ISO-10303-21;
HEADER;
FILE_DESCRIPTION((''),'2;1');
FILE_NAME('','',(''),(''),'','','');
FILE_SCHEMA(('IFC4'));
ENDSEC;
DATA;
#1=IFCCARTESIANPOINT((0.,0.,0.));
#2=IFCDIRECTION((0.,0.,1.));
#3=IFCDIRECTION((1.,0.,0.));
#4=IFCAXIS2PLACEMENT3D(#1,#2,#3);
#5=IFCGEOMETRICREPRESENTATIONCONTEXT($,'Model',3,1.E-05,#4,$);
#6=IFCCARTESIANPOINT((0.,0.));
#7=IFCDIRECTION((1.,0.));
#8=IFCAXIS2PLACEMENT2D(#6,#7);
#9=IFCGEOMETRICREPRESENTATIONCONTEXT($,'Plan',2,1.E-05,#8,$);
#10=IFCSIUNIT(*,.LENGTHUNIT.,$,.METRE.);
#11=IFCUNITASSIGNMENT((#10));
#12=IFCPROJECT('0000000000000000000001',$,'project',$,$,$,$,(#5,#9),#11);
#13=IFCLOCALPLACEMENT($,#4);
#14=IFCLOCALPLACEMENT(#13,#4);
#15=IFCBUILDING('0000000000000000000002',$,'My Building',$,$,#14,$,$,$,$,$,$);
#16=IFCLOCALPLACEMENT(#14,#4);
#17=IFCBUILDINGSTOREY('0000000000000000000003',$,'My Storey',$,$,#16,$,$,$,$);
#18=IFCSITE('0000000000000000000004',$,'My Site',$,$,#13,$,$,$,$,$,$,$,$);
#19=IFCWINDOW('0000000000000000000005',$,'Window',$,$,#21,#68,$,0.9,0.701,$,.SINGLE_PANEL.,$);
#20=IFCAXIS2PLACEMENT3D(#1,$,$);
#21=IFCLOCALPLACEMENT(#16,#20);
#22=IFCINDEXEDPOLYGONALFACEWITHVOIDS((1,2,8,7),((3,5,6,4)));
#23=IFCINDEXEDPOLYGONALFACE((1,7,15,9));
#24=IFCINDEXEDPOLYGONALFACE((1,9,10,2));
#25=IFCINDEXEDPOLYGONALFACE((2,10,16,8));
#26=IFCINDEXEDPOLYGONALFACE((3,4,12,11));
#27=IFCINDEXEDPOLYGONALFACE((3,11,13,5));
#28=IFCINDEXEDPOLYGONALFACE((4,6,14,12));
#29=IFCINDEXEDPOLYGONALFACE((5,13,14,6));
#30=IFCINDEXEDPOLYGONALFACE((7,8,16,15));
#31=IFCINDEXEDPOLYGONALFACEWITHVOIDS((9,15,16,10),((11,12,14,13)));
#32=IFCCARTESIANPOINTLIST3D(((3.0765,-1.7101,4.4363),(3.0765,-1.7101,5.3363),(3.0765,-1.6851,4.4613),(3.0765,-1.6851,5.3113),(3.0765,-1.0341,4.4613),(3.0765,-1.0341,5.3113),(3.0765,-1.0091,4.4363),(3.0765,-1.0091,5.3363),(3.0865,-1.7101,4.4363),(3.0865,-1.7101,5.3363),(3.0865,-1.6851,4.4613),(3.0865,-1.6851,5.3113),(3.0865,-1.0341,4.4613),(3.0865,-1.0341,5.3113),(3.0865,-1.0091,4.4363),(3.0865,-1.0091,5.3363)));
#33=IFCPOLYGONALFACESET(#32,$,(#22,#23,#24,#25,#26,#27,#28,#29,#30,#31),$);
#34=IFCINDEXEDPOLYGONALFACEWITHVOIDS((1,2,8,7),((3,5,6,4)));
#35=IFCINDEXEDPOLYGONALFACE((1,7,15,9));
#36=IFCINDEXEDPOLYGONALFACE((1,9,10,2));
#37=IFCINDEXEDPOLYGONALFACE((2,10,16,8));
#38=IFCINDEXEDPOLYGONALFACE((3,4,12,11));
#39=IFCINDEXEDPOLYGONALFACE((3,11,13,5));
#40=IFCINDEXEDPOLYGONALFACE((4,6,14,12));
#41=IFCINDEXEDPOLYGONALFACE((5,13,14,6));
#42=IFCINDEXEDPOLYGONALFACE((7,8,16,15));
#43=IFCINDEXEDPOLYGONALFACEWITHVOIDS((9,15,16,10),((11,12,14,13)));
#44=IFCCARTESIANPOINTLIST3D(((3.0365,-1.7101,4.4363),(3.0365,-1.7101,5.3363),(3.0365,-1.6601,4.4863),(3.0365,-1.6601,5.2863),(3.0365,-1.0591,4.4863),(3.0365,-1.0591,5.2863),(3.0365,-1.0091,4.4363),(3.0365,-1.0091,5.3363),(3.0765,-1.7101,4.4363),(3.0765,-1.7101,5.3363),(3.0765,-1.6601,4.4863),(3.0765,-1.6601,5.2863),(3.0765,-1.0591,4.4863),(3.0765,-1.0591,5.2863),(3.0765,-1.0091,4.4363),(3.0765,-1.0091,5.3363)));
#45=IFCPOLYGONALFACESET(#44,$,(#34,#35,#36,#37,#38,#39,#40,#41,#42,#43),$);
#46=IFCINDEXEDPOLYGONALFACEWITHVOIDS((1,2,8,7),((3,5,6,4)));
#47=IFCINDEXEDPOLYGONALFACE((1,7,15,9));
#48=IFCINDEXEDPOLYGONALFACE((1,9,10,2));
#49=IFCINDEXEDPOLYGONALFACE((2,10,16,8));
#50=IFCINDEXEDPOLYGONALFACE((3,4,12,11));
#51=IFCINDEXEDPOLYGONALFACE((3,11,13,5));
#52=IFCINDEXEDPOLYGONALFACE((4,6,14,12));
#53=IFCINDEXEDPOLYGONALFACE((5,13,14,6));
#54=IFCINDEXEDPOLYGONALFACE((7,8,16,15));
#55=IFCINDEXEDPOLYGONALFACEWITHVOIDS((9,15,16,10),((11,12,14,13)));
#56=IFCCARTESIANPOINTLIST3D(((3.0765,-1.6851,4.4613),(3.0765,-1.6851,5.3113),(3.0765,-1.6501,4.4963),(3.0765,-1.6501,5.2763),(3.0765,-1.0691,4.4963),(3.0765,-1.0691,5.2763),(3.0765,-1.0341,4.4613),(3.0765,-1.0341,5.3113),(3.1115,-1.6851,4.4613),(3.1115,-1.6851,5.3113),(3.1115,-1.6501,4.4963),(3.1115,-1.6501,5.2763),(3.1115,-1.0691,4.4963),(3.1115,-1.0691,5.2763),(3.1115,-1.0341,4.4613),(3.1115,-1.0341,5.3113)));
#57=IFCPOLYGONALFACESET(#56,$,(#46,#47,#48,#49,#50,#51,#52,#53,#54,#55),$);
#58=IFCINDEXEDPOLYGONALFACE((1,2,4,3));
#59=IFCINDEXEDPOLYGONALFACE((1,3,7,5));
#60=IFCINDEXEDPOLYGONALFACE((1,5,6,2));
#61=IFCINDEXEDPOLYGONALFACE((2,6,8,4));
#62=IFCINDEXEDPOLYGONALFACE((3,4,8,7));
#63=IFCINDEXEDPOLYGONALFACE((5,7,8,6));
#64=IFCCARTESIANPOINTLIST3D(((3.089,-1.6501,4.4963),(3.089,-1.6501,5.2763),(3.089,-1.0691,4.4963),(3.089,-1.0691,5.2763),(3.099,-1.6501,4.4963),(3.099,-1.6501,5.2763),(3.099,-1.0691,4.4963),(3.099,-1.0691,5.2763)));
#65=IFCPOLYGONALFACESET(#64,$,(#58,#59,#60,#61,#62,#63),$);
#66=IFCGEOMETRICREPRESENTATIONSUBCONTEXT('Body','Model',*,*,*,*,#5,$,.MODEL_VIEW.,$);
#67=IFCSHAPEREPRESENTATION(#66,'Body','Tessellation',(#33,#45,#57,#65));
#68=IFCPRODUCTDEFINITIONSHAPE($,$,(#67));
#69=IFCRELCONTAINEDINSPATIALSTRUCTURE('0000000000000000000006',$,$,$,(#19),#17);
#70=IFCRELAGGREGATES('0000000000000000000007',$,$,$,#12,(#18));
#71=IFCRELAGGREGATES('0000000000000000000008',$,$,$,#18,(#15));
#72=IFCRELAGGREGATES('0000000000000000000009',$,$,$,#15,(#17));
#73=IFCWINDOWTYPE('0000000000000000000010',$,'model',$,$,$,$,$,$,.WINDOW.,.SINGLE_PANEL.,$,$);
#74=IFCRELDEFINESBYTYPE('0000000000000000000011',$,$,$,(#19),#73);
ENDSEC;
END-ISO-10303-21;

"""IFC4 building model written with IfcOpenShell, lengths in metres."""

from ifc_helpers import new_model, entity, si_unit, frame, origin_with_axes, origin_2d_with_axis, place, context, subcontext, project, spatial, line, indexed_curve, outline, extrude, shape, source, transform, mapped, type_object, type_shapes, element, save


model = new_model("IFC4")

# Units and contexts
model_context = context("Model", 3, precision=1e-05, world=origin_with_axes())
plan_context = context("Plan", 2, precision=1e-05, world=origin_2d_with_axis())
body_context_1 = subcontext(model_context, "Body", "Model", "MODEL_VIEW")
body_context_2 = subcontext(plan_context, "Body", "Plan", "PLAN_VIEW")
ifc_project = project(units=[si_unit("LENGTHUNIT", "METRE")], contexts=[model_context, plan_context])

# Site, building, storey
site_placement = place(None, origin_with_axes())
site = spatial("IfcSite", under=ifc_project, at=site_placement, Name="My Site")
building_placement = place(site_placement, origin_with_axes())
building = spatial("IfcBuilding", under=site, at=building_placement, Name="My Building")
storey_placement = place(building_placement, origin_with_axes())
storey = spatial("IfcBuildingStorey", under=building, at=storey_placement, Name="My Storey")

# Window
window_type_1 = type_object("IfcWindowType", Name="model", PartitioningType="SINGLE_PANEL", PredefinedType="WINDOW")
shared_shape_1 = source(origin_with_axes(), body_context_1, "Body", "SweptSolid", [
    extrude(outline(indexed_curve([(0.0, 0.0), (0.701, 0.0), (0.701, 0.9), (0.0, 0.9)], segments=[line(1, 2, 3, 4, 1)]), holes=[indexed_curve([(0.025, 0.025), (0.676, 0.025), (0.676, 0.875), (0.025, 0.875)], segments=[line(1, 2, 3, 4, 1)])]), frame((0.0, 0.09, 0.0), z_axis=(0.0, -1.0, 0.0), x_axis=(1.0, 0.0, 0.0)), (0.0, 0.0, -1.0), 0.01),
    extrude(outline(indexed_curve([(0.0, 0.0), (0.701, 0.0), (0.701, 0.9), (0.0, 0.9)], segments=[line(1, 2, 3, 4, 1)]), holes=[indexed_curve([(0.05, 0.05), (0.651, 0.05), (0.651, 0.85), (0.05, 0.85)], segments=[line(1, 2, 3, 4, 1)])]), frame((0.0, 0.05, 0.0), z_axis=(0.0, -1.0, 0.0), x_axis=(1.0, 0.0, 0.0)), (0.0, 0.0, -1.0), 0.04),
    extrude(outline(indexed_curve([(0.0, 0.0), (0.651, 0.0), (0.651, 0.85), (0.0, 0.85)], segments=[line(1, 2, 3, 4, 1)]), holes=[indexed_curve([(0.035, 0.035), (0.616, 0.035), (0.616, 0.815), (0.035, 0.815)], segments=[line(1, 2, 3, 4, 1)])]), frame((0.025, 0.09, 0.025), z_axis=(0.0, -1.0, 0.0), x_axis=(1.0, 0.0, 0.0)), (0.0, 0.0, -1.0), 0.035),
    extrude(outline(indexed_curve([(0.035, 0.035), (0.616, 0.035), (0.616, 0.815), (0.035, 0.815)], segments=[line(1, 2, 3, 4, 1)])), frame((0.025, 0.1025, 0.025), z_axis=(0.0, -1.0, 0.0), x_axis=(1.0, 0.0, 0.0)), (0.0, 0.0, -1.0), 0.01),
])
shared_shape_2 = source(origin_with_axes(), body_context_2, "Body", "Curve2D", [
    entity("IfcIndexedPolyCurve", entity("IfcCartesianPointList2D", [[0.05, 0.05], [0.651, 0.05]])),
    entity("IfcIndexedPolyCurve", entity("IfcCartesianPointList2D", [[0.0, 0.1], [0.025, 0.1], [0.025, 0.09], [0.05, 0.09], [0.05, 0.05], [0.0, 0.05]]), [entity("IfcLineIndex", [1, 2, 3, 4, 5, 6, 1])]),
    entity("IfcIndexedPolyCurve", entity("IfcCartesianPointList2D", [[0.701, 0.1], [0.676, 0.1], [0.676, 0.09], [0.651, 0.09], [0.651, 0.05], [0.701, 0.05]]), [entity("IfcLineIndex", [1, 2, 3, 4, 5, 6, 1])]),
    entity("IfcIndexedPolyCurve", entity("IfcCartesianPointList2D", [[0.025, 0.09], [0.06, 0.09], [0.06, 0.125], [0.025, 0.125]]), [entity("IfcLineIndex", [1, 2, 3, 4, 1])]),
    entity("IfcIndexedPolyCurve", entity("IfcCartesianPointList2D", [[0.676, 0.09], [0.641, 0.09], [0.641, 0.125], [0.676, 0.125]]), [entity("IfcLineIndex", [1, 2, 3, 4, 1])]),
    entity("IfcIndexedPolyCurve", entity("IfcCartesianPointList2D", [[0.06, 0.09], [0.641, 0.09]])),
    entity("IfcIndexedPolyCurve", entity("IfcCartesianPointList2D", [[0.06, 0.125], [0.641, 0.125]])),
    entity("IfcIndexedPolyCurve", entity("IfcCartesianPointList2D", [[0.06, 0.1075], [0.641, 0.1075]])),
])
type_shapes(window_type_1, [shared_shape_1, shared_shape_2])
for number, where, z_axis, x_axis, name in (
    (1, (2.9865, -1.0091, 4.4363), (0.0, 0.0, 1.0), (0.0, -1.0, 0.0), "Window"),
):
    element("IfcWindow", number, at=place(storey_placement, frame(where, z_axis=z_axis, x_axis=x_axis)), inside=storey, type_object=window_type_1, Name=name, OverallHeight=0.9, OverallWidth=0.701, PartitioningType="SINGLE_PANEL", shapes=[
        shape(body_context_1, "Body", "MappedRepresentation", [mapped(shared_shape_1, transform((0.0, 0.0, 0.0), x_axis=(1.0, 0.0, 0.0), y_axis=(0.0, 1.0, 0.0), z_axis=(0.0, 0.0, 1.0), scale=1.0))]),
        shape(body_context_2, "Body", "MappedRepresentation", [mapped(shared_shape_2, transform((0.0, 0.0, 0.0), x_axis=(1.0, 0.0, 0.0), y_axis=(0.0, 1.0, 0.0), z_axis=(0.0, 0.0, 1.0), scale=1.0))]),
    ])

save(model, "model.ifc")
